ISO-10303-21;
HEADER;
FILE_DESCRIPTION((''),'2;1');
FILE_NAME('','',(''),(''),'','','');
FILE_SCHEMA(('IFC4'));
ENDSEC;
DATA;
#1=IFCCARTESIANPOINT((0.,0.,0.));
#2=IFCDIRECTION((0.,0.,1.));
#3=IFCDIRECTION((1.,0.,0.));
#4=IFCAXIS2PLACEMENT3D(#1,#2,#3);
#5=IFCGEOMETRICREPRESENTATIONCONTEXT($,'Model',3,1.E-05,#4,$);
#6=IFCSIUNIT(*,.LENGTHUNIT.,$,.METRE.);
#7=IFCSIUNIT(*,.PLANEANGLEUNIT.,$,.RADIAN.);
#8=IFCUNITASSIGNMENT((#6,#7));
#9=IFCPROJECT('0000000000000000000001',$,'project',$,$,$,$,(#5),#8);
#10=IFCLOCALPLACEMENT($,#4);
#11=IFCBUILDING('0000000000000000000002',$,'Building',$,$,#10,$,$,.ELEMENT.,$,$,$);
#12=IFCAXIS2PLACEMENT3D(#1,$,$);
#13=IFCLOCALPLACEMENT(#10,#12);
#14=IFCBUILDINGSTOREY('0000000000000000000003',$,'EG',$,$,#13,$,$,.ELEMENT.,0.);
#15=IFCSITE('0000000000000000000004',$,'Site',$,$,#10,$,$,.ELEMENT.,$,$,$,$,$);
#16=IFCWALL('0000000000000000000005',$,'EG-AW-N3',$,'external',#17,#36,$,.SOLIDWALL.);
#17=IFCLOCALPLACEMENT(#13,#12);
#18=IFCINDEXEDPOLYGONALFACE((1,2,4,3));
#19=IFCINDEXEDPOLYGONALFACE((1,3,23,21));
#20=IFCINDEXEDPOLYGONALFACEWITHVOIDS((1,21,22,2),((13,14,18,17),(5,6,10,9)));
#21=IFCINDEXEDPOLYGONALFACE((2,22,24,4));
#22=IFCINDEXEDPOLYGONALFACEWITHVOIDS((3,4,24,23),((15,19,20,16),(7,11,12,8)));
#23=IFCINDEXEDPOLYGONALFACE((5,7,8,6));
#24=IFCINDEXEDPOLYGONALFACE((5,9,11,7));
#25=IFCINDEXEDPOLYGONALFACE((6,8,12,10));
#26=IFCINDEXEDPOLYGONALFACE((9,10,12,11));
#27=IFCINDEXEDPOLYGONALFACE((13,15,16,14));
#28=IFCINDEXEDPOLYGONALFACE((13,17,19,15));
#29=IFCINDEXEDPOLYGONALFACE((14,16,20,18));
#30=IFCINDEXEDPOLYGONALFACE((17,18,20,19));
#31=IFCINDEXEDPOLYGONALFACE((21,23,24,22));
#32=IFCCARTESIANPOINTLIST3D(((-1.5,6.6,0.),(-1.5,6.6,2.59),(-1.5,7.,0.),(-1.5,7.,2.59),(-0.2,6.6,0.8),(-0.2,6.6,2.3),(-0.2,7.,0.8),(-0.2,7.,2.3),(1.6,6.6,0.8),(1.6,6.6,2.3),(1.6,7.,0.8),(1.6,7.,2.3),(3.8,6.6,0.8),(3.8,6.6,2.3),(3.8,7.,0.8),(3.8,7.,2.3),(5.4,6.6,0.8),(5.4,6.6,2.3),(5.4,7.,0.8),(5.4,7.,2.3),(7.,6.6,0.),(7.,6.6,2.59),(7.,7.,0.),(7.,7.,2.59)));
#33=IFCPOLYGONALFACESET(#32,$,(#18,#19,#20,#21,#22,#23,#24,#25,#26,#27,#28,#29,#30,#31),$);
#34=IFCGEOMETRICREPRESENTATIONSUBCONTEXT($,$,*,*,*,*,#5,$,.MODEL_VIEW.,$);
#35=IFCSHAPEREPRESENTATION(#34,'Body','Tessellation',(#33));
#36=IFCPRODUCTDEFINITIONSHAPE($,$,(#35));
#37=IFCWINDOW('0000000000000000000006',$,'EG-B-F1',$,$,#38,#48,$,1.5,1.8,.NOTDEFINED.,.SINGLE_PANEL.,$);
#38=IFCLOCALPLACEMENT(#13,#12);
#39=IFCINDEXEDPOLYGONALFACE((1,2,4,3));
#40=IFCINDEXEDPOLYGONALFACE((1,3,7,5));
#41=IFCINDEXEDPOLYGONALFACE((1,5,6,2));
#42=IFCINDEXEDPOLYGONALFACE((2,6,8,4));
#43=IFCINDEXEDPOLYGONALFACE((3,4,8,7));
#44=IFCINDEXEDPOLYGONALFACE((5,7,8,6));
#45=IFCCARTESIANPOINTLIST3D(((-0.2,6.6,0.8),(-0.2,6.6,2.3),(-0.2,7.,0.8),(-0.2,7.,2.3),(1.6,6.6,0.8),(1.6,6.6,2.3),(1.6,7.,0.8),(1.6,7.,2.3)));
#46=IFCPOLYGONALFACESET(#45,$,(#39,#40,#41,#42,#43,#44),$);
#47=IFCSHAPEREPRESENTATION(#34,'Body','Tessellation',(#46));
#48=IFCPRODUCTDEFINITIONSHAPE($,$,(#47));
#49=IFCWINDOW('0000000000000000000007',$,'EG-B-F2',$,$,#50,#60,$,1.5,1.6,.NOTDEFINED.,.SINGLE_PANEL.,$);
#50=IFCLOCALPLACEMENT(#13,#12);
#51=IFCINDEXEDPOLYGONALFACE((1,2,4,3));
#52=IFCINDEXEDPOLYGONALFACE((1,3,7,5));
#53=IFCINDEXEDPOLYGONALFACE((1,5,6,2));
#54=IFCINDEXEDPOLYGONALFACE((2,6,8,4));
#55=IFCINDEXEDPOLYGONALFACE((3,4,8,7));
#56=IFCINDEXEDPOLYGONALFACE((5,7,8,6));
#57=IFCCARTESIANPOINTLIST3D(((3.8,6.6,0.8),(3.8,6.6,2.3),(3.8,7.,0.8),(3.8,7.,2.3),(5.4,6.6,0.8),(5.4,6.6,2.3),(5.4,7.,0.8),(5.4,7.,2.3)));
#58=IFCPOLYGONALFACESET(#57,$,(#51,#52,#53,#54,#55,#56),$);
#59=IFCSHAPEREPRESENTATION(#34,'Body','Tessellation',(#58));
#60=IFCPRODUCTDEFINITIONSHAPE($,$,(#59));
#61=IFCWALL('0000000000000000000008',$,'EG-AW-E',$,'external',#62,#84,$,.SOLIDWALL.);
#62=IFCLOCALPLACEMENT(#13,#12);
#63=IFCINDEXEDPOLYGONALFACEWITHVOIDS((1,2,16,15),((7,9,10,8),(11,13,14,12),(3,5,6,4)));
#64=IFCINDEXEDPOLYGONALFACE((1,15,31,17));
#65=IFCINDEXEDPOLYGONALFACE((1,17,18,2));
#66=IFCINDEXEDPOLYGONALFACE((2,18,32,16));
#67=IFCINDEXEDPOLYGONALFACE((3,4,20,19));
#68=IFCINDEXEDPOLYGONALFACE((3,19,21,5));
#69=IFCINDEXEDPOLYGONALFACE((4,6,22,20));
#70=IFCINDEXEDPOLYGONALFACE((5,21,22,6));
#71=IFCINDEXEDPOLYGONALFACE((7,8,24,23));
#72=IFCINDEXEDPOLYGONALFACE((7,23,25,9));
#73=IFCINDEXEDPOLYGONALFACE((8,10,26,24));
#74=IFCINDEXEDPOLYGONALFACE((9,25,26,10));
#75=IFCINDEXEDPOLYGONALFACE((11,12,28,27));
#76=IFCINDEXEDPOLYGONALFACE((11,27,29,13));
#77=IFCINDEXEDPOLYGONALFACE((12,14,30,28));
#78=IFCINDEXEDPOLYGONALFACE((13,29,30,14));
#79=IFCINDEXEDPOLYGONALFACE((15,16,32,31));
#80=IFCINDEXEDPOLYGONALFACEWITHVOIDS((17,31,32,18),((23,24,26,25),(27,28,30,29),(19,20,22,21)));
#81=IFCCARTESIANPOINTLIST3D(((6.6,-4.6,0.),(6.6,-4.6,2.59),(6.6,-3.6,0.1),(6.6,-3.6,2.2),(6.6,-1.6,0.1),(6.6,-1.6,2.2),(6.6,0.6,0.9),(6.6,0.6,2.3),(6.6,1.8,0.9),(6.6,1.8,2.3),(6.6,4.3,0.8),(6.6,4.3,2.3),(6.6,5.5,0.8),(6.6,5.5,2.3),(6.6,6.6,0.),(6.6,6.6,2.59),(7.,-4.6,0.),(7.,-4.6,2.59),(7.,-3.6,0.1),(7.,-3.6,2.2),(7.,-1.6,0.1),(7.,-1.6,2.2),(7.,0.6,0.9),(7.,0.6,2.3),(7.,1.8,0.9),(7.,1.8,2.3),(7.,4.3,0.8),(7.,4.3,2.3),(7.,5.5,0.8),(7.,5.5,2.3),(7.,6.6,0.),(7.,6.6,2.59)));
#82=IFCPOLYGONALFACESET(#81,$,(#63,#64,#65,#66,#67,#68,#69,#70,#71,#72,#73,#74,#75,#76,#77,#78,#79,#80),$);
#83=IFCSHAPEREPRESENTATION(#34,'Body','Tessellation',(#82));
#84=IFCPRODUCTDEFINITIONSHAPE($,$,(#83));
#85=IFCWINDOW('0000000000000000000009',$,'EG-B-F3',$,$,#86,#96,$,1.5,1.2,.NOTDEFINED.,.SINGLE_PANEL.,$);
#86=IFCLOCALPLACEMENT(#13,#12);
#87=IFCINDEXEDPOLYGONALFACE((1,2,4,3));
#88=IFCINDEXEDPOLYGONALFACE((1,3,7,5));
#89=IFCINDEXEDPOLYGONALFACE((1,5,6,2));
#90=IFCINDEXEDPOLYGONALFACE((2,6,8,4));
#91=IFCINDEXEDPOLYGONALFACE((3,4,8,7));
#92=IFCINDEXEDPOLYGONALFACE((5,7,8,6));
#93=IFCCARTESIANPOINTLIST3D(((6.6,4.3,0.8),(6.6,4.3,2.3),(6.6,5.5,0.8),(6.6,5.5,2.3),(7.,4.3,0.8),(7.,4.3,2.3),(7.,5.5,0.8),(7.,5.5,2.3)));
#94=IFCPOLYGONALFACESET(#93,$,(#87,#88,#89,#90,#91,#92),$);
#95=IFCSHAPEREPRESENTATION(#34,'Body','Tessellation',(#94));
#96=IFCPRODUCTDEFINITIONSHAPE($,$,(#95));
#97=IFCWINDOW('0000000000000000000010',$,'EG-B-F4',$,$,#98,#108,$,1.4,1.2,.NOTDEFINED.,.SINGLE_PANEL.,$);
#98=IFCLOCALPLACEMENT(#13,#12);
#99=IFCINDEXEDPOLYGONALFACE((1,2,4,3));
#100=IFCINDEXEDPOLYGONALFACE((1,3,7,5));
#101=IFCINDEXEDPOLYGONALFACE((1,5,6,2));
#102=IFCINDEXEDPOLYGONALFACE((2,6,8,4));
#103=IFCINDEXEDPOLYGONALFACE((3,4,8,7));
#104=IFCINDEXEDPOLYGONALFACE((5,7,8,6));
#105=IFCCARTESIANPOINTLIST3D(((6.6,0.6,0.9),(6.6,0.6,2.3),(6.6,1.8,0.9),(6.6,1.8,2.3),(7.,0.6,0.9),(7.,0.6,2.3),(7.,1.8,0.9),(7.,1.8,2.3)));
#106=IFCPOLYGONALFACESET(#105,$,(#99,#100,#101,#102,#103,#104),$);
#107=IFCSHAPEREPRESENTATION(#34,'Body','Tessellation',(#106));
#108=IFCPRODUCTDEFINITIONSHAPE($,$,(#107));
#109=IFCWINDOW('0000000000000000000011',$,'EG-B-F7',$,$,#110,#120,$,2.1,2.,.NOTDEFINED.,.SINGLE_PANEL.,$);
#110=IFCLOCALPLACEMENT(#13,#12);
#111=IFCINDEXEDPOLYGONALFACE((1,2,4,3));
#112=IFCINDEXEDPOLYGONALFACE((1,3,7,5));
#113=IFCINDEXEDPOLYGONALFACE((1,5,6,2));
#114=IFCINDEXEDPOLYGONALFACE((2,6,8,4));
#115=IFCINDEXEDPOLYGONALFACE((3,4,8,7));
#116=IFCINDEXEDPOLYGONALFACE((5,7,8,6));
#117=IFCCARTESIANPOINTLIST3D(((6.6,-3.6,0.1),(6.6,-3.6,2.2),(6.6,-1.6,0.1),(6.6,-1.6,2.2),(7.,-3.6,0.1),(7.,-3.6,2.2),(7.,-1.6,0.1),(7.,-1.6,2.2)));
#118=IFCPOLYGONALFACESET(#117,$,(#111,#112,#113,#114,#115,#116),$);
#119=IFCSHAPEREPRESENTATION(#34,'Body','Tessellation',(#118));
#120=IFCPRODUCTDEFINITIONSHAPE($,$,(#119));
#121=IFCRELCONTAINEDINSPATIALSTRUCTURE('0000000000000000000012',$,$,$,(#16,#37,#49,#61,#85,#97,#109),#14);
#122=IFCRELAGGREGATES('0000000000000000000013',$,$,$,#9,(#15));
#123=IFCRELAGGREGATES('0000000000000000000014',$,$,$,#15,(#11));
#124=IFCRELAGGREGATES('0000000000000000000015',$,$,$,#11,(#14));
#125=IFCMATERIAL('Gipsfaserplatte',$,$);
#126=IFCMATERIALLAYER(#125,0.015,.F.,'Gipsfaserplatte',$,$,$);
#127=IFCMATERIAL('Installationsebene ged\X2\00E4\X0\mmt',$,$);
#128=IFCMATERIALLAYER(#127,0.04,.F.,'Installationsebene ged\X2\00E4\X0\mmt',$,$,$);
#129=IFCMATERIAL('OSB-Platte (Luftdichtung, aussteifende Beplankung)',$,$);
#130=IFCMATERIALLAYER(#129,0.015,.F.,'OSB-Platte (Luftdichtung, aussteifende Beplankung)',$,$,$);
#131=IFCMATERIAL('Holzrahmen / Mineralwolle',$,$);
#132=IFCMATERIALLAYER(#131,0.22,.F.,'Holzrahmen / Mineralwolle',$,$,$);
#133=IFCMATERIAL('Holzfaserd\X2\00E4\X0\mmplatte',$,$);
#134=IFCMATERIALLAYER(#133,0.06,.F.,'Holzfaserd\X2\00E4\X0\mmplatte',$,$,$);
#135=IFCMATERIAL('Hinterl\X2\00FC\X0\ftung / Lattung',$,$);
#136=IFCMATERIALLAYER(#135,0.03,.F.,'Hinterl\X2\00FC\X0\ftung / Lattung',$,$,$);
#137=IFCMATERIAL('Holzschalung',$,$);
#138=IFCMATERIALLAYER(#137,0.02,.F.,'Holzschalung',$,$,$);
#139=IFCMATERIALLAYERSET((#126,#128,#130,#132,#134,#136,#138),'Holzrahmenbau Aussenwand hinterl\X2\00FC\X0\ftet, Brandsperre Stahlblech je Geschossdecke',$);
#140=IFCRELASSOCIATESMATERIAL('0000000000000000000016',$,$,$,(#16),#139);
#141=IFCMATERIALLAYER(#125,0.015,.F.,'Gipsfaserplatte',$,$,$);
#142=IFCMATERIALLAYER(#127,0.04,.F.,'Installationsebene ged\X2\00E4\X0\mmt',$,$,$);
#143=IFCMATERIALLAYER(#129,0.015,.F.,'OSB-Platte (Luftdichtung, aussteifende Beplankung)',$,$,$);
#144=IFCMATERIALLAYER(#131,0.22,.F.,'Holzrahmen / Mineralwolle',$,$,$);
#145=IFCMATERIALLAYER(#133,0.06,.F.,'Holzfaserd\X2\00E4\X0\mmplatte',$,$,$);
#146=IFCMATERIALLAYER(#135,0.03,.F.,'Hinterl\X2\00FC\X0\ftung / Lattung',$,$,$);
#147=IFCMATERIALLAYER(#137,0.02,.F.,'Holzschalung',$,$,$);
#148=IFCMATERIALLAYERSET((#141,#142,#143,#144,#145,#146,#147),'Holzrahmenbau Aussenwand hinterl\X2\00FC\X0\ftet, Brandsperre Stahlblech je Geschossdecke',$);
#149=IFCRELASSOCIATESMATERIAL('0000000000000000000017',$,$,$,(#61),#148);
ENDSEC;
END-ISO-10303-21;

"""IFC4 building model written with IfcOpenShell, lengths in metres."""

from ifc_helpers import new_model, si_unit, frame, frame_2d, origin, origin_with_axes, place, context, subcontext, project, spatial, rectangle, extrude, material, layer, layer_set, element, fill, save


model = new_model("IFC4")

# Units and contexts
model_context = context("Model", 3, precision=1e-05, world=origin_with_axes())
sub_context = subcontext(model_context, None, None, "MODEL_VIEW")
ifc_project = project(units=[si_unit("LENGTHUNIT", "METRE"), si_unit("PLANEANGLEUNIT", "RADIAN")], contexts=[model_context])

# Site, building, storey
placement = place(None, origin_with_axes())
site = spatial("IfcSite", under=ifc_project, at=placement, Name="Site", CompositionType="ELEMENT")
building = spatial("IfcBuilding", under=site, at=placement, Name="Building", CompositionType="ELEMENT")
storey_placement = place(placement, origin())
storey = spatial("IfcBuildingStorey", under=building, at=storey_placement, Name="EG", CompositionType="ELEMENT", Elevation=0.0)

# Walls, openings, windows
ifc_material_1 = material(Name="Gipsfaserplatte")
ifc_layer_1 = layer(ifc_material_1, 0.015, ventilated=False, Name="Gipsfaserplatte")
ifc_material_2 = material(Name="Installationsebene gedämmt")
ifc_layer_2 = layer(ifc_material_2, 0.04, ventilated=False, Name="Installationsebene gedämmt")
ifc_material_3 = material(Name="OSB-Platte (Luftdichtung, aussteifende Beplankung)")
ifc_layer_3 = layer(ifc_material_3, 0.015, ventilated=False, Name="OSB-Platte (Luftdichtung, aussteifende Beplankung)")
ifc_material_4 = material(Name="Holzrahmen / Mineralwolle")
ifc_layer_4 = layer(ifc_material_4, 0.22, ventilated=False, Name="Holzrahmen / Mineralwolle")
ifc_material_5 = material(Name="Holzfaserdämmplatte")
ifc_layer_5 = layer(ifc_material_5, 0.06, ventilated=False, Name="Holzfaserdämmplatte")
ifc_material_6 = material(Name="Hinterlüftung / Lattung")
ifc_layer_6 = layer(ifc_material_6, 0.03, ventilated=False, Name="Hinterlüftung / Lattung")
ifc_material_7 = material(Name="Holzschalung")
ifc_layer_7 = layer(ifc_material_7, 0.02, ventilated=False, Name="Holzschalung")
ifc_layer_set_1 = layer_set([ifc_layer_1, ifc_layer_2, ifc_layer_3, ifc_layer_4, ifc_layer_5, ifc_layer_6, ifc_layer_7], Name="Holzrahmenbau Aussenwand hinterlüftet, Brandsperre Stahlblech je Geschossdecke")
wall_1_placement = place(storey_placement, frame((-1.5, 6.8, 0.0), z_axis=(0.0, 0.0, 1.0), x_axis=(1.0, 0.0, 0.0)))
wall_1 = element("IfcWall", 1, at=wall_1_placement, inside=storey, material=ifc_layer_set_1, Name="EG-AW-N3", ObjectType="external", PredefinedType="SOLIDWALL", context=sub_context, shape_type="SweptSolid", body=[
    extrude(rectangle(XDim=8.5, YDim=0.4, at=frame_2d((4.25, 0.0))), origin(), (0.0, 0.0, 1.0), 2.59),
])
opening_1_placement = place(wall_1_placement, frame((2.2, 0.25, 0.8), z_axis=(0.0, -1.0, 0.0), x_axis=(1.0, 0.0, 0.0)))
opening_1 = element("IfcOpeningElement", 2, at=opening_1_placement, cuts=wall_1, PredefinedType="OPENING", context=sub_context, shape_type="SweptSolid", body=[
    extrude(rectangle(XDim=1.8, YDim=1.5, at=frame_2d((0.0, 0.75))), origin(), (0.0, 0.0, 1.0), 0.5),
])
opening_2_placement = place(wall_1_placement, frame((6.1, 0.25, 0.8), z_axis=(0.0, -1.0, 0.0), x_axis=(1.0, 0.0, 0.0)))
opening_2 = element("IfcOpeningElement", 3, at=opening_2_placement, cuts=wall_1, PredefinedType="OPENING", context=sub_context, shape_type="SweptSolid", body=[
    extrude(rectangle(XDim=1.6, YDim=1.5, at=frame_2d((0.0, 0.75))), origin(), (0.0, 0.0, 1.0), 0.5),
])
window_1_placement = place(wall_1_placement, frame((2.2, 0.2, 0.8), z_axis=(0.0, -1.0, 0.0), x_axis=(1.0, 0.0, 0.0)))
window_1 = element("IfcWindow", 4, at=window_1_placement, inside=storey, Name="EG-B-F1", OverallHeight=1.5, OverallWidth=1.8, PartitioningType="SINGLE_PANEL", PredefinedType="NOTDEFINED", context=sub_context, shape_type="SweptSolid", body=[
    extrude(rectangle(XDim=1.8, YDim=1.5, at=frame_2d((0.0, 0.75))), origin(), (0.0, 0.0, 1.0), 0.4),
])
fill(opening_1, window_1)
window_2_placement = place(wall_1_placement, frame((6.1, 0.2, 0.8), z_axis=(0.0, -1.0, 0.0), x_axis=(1.0, 0.0, 0.0)))
window_2 = element("IfcWindow", 5, at=window_2_placement, inside=storey, Name="EG-B-F2", OverallHeight=1.5, OverallWidth=1.6, PartitioningType="SINGLE_PANEL", PredefinedType="NOTDEFINED", context=sub_context, shape_type="SweptSolid", body=[
    extrude(rectangle(XDim=1.6, YDim=1.5, at=frame_2d((0.0, 0.75))), origin(), (0.0, 0.0, 1.0), 0.4),
])
fill(opening_2, window_2)
ifc_layer_8 = layer(ifc_material_1, 0.015, ventilated=False, Name="Gipsfaserplatte")
ifc_layer_9 = layer(ifc_material_2, 0.04, ventilated=False, Name="Installationsebene gedämmt")
ifc_layer_10 = layer(ifc_material_3, 0.015, ventilated=False, Name="OSB-Platte (Luftdichtung, aussteifende Beplankung)")
ifc_layer_11 = layer(ifc_material_4, 0.22, ventilated=False, Name="Holzrahmen / Mineralwolle")
ifc_layer_12 = layer(ifc_material_5, 0.06, ventilated=False, Name="Holzfaserdämmplatte")
ifc_layer_13 = layer(ifc_material_6, 0.03, ventilated=False, Name="Hinterlüftung / Lattung")
ifc_layer_14 = layer(ifc_material_7, 0.02, ventilated=False, Name="Holzschalung")
ifc_layer_set_2 = layer_set([ifc_layer_8, ifc_layer_9, ifc_layer_10, ifc_layer_11, ifc_layer_12, ifc_layer_13, ifc_layer_14], Name="Holzrahmenbau Aussenwand hinterlüftet, Brandsperre Stahlblech je Geschossdecke")
wall_2_placement = place(storey_placement, frame((6.8, 6.6, 0.0), z_axis=(0.0, 0.0, 1.0), x_axis=(0.0, -1.0, 0.0)))
wall_2 = element("IfcWall", 6, at=wall_2_placement, inside=storey, material=ifc_layer_set_2, Name="EG-AW-E", ObjectType="external", PredefinedType="SOLIDWALL", context=sub_context, shape_type="SweptSolid", body=[
    extrude(rectangle(XDim=11.2, YDim=0.4, at=frame_2d((5.6, 0.0))), origin(), (0.0, 0.0, 1.0), 2.59),
])
opening_3_placement = place(wall_2_placement, frame((1.7, 0.25, 0.8), z_axis=(0.0, -1.0, 0.0), x_axis=(1.0, 0.0, 0.0)))
opening_3 = element("IfcOpeningElement", 7, at=opening_3_placement, cuts=wall_2, PredefinedType="OPENING", context=sub_context, shape_type="SweptSolid", body=[
    extrude(rectangle(XDim=1.2, YDim=1.5, at=frame_2d((0.0, 0.75))), origin(), (0.0, 0.0, 1.0), 0.5),
])
opening_4_placement = place(wall_2_placement, frame((5.4, 0.25, 0.9), z_axis=(0.0, -1.0, 0.0), x_axis=(1.0, 0.0, 0.0)))
opening_4 = element("IfcOpeningElement", 8, at=opening_4_placement, cuts=wall_2, PredefinedType="OPENING", context=sub_context, shape_type="SweptSolid", body=[
    extrude(rectangle(XDim=1.2, YDim=1.4, at=frame_2d((0.0, 0.7))), origin(), (0.0, 0.0, 1.0), 0.5),
])
opening_5_placement = place(wall_2_placement, frame((9.2, 0.25, 0.1), z_axis=(0.0, -1.0, 0.0), x_axis=(1.0, 0.0, 0.0)))
opening_5 = element("IfcOpeningElement", 9, at=opening_5_placement, cuts=wall_2, PredefinedType="OPENING", context=sub_context, shape_type="SweptSolid", body=[
    extrude(rectangle(XDim=2.0, YDim=2.1, at=frame_2d((0.0, 1.05))), origin(), (0.0, 0.0, 1.0), 0.5),
])
window_3_placement = place(wall_2_placement, frame((1.7, 0.2, 0.8), z_axis=(0.0, -1.0, 0.0), x_axis=(1.0, 0.0, 0.0)))
window_3 = element("IfcWindow", 10, at=window_3_placement, inside=storey, Name="EG-B-F3", OverallHeight=1.5, OverallWidth=1.2, PartitioningType="SINGLE_PANEL", PredefinedType="NOTDEFINED", context=sub_context, shape_type="SweptSolid", body=[
    extrude(rectangle(XDim=1.2, YDim=1.5, at=frame_2d((0.0, 0.75))), origin(), (0.0, 0.0, 1.0), 0.4),
])
fill(opening_3, window_3)
window_4_placement = place(wall_2_placement, frame((5.4, 0.2, 0.9), z_axis=(0.0, -1.0, 0.0), x_axis=(1.0, 0.0, 0.0)))
window_4 = element("IfcWindow", 11, at=window_4_placement, inside=storey, Name="EG-B-F4", OverallHeight=1.4, OverallWidth=1.2, PartitioningType="SINGLE_PANEL", PredefinedType="NOTDEFINED", context=sub_context, shape_type="SweptSolid", body=[
    extrude(rectangle(XDim=1.2, YDim=1.4, at=frame_2d((0.0, 0.7))), origin(), (0.0, 0.0, 1.0), 0.4),
])
fill(opening_4, window_4)
window_5_placement = place(wall_2_placement, frame((9.2, 0.2, 0.1), z_axis=(0.0, -1.0, 0.0), x_axis=(1.0, 0.0, 0.0)))
window_5 = element("IfcWindow", 12, at=window_5_placement, inside=storey, Name="EG-B-F7", OverallHeight=2.1, OverallWidth=2.0, PartitioningType="SINGLE_PANEL", PredefinedType="NOTDEFINED", context=sub_context, shape_type="SweptSolid", body=[
    extrude(rectangle(XDim=2.0, YDim=2.1, at=frame_2d((0.0, 1.05))), origin(), (0.0, 0.0, 1.0), 0.4),
])
fill(opening_5, window_5)

save(model, "model.ifc")
